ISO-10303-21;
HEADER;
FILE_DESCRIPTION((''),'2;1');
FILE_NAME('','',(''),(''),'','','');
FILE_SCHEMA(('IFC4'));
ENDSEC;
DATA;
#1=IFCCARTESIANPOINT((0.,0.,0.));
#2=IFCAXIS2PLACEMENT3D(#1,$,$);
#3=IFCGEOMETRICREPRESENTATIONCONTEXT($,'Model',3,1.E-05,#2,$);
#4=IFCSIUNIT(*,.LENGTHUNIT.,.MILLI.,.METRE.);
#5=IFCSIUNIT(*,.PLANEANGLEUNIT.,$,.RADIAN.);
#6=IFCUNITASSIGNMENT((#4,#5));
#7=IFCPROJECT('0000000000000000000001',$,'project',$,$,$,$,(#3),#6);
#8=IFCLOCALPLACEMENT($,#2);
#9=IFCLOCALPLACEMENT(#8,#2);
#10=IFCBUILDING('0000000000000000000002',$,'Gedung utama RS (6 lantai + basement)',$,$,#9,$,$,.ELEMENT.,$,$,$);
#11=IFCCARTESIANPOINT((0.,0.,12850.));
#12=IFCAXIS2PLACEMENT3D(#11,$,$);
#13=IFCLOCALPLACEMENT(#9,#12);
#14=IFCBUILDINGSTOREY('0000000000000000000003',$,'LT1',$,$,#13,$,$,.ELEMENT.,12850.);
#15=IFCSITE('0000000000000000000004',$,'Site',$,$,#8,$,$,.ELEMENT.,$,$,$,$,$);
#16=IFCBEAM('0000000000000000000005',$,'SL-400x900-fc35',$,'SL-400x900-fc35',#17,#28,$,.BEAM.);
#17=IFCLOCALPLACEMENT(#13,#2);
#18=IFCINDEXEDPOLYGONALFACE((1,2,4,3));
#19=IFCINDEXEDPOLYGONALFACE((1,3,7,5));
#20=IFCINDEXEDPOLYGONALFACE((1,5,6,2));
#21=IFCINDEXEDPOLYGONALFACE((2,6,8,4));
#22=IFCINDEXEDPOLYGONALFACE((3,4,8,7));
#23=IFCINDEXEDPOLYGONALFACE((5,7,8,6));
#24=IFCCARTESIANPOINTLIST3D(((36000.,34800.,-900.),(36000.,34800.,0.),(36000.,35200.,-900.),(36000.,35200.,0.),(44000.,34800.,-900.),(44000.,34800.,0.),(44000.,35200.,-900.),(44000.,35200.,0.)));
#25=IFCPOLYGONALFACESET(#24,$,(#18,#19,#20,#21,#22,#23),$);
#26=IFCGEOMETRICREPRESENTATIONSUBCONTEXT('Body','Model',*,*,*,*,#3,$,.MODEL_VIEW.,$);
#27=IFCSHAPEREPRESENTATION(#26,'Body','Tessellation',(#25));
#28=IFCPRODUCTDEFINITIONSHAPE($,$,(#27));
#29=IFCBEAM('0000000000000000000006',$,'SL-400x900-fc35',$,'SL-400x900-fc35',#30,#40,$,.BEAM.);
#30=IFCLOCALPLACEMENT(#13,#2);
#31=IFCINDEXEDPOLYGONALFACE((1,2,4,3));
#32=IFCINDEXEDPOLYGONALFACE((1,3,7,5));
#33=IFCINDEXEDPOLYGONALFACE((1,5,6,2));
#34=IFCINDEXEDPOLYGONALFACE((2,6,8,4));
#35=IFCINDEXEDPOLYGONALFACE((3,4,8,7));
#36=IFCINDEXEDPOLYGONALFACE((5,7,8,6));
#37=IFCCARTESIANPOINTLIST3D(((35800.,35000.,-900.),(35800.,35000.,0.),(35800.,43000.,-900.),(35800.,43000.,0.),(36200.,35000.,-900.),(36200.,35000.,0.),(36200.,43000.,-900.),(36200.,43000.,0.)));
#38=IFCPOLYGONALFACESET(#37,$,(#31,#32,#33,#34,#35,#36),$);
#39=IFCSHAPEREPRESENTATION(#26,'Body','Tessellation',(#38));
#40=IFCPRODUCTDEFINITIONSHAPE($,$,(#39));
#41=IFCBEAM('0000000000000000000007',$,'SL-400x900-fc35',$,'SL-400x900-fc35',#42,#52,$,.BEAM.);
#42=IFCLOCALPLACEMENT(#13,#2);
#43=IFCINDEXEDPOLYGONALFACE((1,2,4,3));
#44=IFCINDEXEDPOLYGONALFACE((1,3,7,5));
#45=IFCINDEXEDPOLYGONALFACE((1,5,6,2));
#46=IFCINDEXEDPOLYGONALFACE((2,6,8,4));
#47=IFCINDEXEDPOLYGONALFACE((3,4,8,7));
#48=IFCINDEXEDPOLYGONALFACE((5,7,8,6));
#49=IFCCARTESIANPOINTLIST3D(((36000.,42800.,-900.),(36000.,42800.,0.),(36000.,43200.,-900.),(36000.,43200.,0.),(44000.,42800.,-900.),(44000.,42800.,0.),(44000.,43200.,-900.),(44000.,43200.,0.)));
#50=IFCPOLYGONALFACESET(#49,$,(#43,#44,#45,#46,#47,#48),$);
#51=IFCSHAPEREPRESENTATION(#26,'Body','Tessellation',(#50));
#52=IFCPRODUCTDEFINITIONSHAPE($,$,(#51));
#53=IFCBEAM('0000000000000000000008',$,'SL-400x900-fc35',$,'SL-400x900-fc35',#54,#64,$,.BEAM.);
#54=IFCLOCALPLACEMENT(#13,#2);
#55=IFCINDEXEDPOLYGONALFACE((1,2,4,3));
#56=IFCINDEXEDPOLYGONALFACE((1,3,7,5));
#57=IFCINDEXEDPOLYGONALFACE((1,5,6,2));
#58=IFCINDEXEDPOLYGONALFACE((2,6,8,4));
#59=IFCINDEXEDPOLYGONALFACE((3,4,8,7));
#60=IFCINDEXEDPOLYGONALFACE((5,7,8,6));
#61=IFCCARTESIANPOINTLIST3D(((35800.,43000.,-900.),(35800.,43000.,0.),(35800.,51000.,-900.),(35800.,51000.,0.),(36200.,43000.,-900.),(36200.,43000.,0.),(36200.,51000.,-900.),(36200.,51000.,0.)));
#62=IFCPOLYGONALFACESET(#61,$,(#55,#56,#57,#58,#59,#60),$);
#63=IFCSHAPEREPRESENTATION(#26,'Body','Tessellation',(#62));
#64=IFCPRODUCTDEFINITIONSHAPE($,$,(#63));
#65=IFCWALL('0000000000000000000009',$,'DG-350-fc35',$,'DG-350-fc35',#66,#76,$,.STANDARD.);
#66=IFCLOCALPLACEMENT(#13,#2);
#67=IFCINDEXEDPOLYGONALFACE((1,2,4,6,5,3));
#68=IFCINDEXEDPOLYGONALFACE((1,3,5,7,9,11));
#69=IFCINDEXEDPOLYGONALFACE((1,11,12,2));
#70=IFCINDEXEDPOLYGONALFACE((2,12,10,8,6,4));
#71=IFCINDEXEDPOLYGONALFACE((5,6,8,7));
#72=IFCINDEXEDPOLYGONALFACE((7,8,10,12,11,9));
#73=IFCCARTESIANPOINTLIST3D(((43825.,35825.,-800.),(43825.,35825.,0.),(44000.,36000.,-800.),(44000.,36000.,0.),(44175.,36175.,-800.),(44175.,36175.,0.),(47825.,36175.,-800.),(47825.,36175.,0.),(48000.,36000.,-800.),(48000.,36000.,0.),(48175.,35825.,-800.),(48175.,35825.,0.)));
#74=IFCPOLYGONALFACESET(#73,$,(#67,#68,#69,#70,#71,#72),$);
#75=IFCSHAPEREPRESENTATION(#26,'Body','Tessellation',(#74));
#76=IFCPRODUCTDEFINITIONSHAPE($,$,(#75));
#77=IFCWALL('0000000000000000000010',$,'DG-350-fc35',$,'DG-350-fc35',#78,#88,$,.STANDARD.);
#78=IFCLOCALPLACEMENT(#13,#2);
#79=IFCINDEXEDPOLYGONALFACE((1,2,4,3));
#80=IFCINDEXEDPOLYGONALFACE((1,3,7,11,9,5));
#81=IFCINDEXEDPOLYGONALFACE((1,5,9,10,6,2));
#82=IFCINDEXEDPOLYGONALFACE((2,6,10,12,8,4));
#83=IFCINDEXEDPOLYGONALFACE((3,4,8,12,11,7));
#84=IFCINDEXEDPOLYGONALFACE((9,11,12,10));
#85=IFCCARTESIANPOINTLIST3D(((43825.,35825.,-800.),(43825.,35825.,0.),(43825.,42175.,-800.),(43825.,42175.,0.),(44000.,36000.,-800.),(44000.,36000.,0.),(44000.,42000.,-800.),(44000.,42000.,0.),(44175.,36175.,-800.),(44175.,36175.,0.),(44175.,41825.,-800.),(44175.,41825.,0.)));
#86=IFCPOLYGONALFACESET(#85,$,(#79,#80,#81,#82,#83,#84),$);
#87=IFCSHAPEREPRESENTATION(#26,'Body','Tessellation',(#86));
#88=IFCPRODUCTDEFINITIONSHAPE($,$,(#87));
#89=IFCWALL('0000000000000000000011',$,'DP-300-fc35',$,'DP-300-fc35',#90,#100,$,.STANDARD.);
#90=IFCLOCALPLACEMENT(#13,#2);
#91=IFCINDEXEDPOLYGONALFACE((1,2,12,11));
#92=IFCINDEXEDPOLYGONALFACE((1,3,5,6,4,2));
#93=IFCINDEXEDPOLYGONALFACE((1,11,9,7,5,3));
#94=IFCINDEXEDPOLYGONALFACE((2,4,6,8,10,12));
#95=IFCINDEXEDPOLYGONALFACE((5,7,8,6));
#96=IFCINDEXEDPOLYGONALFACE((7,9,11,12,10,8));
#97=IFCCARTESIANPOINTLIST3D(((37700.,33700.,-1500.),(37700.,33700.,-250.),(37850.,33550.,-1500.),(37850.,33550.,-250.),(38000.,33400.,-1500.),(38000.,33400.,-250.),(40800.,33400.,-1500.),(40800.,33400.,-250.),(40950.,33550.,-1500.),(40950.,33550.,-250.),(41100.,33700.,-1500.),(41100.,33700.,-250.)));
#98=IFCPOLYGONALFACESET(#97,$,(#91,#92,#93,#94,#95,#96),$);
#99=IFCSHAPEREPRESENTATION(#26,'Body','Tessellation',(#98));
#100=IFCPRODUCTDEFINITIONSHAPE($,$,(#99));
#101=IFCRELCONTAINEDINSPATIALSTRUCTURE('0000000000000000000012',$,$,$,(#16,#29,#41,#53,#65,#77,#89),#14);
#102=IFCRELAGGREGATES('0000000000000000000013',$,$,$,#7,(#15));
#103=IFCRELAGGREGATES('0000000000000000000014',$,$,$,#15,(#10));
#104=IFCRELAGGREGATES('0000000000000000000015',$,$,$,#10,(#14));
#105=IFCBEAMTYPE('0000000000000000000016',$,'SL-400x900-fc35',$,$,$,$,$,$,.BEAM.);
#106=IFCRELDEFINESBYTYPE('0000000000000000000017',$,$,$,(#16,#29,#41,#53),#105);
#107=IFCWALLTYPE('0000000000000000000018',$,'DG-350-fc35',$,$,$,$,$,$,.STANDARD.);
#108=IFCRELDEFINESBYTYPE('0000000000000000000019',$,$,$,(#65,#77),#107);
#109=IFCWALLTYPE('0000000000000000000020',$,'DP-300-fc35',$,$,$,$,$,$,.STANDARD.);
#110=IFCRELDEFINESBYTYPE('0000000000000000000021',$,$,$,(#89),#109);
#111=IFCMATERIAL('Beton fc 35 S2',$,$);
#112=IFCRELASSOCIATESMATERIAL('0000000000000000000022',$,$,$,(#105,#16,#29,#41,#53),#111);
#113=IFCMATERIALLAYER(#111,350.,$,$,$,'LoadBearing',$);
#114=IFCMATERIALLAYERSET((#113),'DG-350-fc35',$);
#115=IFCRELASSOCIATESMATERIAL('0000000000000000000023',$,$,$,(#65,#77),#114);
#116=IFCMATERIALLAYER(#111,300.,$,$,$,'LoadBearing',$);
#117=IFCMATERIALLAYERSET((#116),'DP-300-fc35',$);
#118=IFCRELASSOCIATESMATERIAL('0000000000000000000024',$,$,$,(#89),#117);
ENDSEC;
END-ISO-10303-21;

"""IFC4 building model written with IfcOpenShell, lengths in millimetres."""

from ifc_helpers import new_model, si_unit, frame, origin, origin_2d, place, context, subcontext, project, spatial, polyline, rectangle, outline, extrude, material, layer, layer_set, layer_usage, material_profile, profile_set, profile_usage, type_object, element, save


model = new_model("IFC4")

# Units and contexts
model_context = context("Model", 3, precision=1e-05, world=origin())
body_context = subcontext(model_context, "Body", "Model", "MODEL_VIEW")
ifc_project = project(units=[si_unit("LENGTHUNIT", "METRE", prefix="MILLI"), si_unit("PLANEANGLEUNIT", "RADIAN")], contexts=[model_context])

# Site, building, storey
site_placement = place(None, origin())
site = spatial("IfcSite", under=ifc_project, at=site_placement, Name="Site", CompositionType="ELEMENT")
building_placement = place(site_placement, origin())
building = spatial("IfcBuilding", under=site, at=building_placement, Name="Gedung utama RS (6 lantai + basement)", CompositionType="ELEMENT")
storey_placement = place(building_placement, frame((0.0, 0.0, 12850.0)))
storey = spatial("IfcBuildingStorey", under=building, at=storey_placement, Name="LT1", CompositionType="ELEMENT", Elevation=12850.0)

# Beams
ifc_material = material(Name="Beton fc 35 S2")
ifc_material_profile_1 = material_profile(ifc_material, rectangle(XDim=400.0, YDim=900.0, at=origin_2d()), Name="SL-400x900-fc35")
ifc_profile_set_1 = profile_set([ifc_material_profile_1], Name="SL-400x900-fc35")
ifc_profile_usage_1 = profile_usage(ifc_profile_set_1, cardinal=8)
beam_type_1 = type_object("IfcBeamType", Name="SL-400x900-fc35", PredefinedType="BEAM", material=ifc_profile_set_1)
beam_1_placement = place(storey_placement, frame((36000.0, 35000.0, -450.0)))
element("IfcBeam", 1, at=beam_1_placement, inside=storey, type_object=beam_type_1, material=ifc_profile_usage_1, Name="SL-400x900-fc35", ObjectType="SL-400x900-fc35", PredefinedType="BEAM", context=body_context, shape_type="SweptSolid", body=[
    extrude(rectangle(XDim=400.0, YDim=900.0, at=origin_2d()), frame((0.0, 0.0, 0.0), z_axis=(1.0, 0.0, 0.0), x_axis=(0.0, 1.0, 0.0)), (0.0, 0.0, 1.0), 8000.0),
])
beam_2_placement = place(storey_placement, frame((36000.0, 35000.0, -450.0)))
element("IfcBeam", 2, at=beam_2_placement, inside=storey, type_object=beam_type_1, material=ifc_profile_usage_1, Name="SL-400x900-fc35", ObjectType="SL-400x900-fc35", PredefinedType="BEAM", context=body_context, shape_type="SweptSolid", body=[
    extrude(rectangle(XDim=400.0, YDim=900.0, at=origin_2d()), frame((0.0, 0.0, 0.0), z_axis=(0.0, 1.0, 0.0), x_axis=(-1.0, 0.0, 0.0)), (0.0, 0.0, 1.0), 8000.0),
])
beam_3_placement = place(storey_placement, frame((36000.0, 43000.0, -450.0)))
element("IfcBeam", 3, at=beam_3_placement, inside=storey, type_object=beam_type_1, material=ifc_profile_usage_1, Name="SL-400x900-fc35", ObjectType="SL-400x900-fc35", PredefinedType="BEAM", context=body_context, shape_type="SweptSolid", body=[
    extrude(rectangle(XDim=400.0, YDim=900.0, at=origin_2d()), frame((0.0, 0.0, 0.0), z_axis=(1.0, 0.0, 0.0), x_axis=(0.0, 1.0, 0.0)), (0.0, 0.0, 1.0), 8000.0),
])
beam_4_placement = place(storey_placement, frame((36000.0, 43000.0, -450.0)))
element("IfcBeam", 4, at=beam_4_placement, inside=storey, type_object=beam_type_1, material=ifc_profile_usage_1, Name="SL-400x900-fc35", ObjectType="SL-400x900-fc35", PredefinedType="BEAM", context=body_context, shape_type="SweptSolid", body=[
    extrude(rectangle(XDim=400.0, YDim=900.0, at=origin_2d()), frame((0.0, 0.0, 0.0), z_axis=(0.0, 1.0, 0.0), x_axis=(-1.0, 0.0, 0.0)), (0.0, 0.0, 1.0), 8000.0),
])

# Walls
ifc_layer_1 = layer(ifc_material, 350.0, Category="LoadBearing")
ifc_layer_set_1 = layer_set([ifc_layer_1], Name="DG-350-fc35")
ifc_layer_usage_1 = layer_usage(ifc_layer_set_1, "AXIS2", "NEGATIVE", 175.0)
wall_type_1 = type_object("IfcWallType", Name="DG-350-fc35", PredefinedType="STANDARD")
wall_1_placement = place(storey_placement, frame((44000.0, 36000.0, -800.0), z_axis=(0.0, 0.0, 1.0), x_axis=(1.0, 0.0, 0.0)))
element("IfcWall", 5, at=wall_1_placement, inside=storey, type_object=wall_type_1, material=ifc_layer_usage_1, Name="DG-350-fc35", ObjectType="DG-350-fc35", PredefinedType="STANDARD", context=body_context, shape_type="SweptSolid", body=[
    extrude(outline(polyline([(-175.0, -175.0), (0.0, 0.0), (175.0, 175.0), (3825.0, 175.0), (4000.0, 0.0), (4175.0, -175.0), (-175.0, -175.0)])), origin(), (0.0, 0.0, 1.0), 800.0),
])
wall_2_placement = place(storey_placement, frame((44000.0, 42000.0, -800.0), z_axis=(0.0, 0.0, 1.0), x_axis=(0.0, -1.0, 0.0)))
element("IfcWall", 6, at=wall_2_placement, inside=storey, type_object=wall_type_1, material=ifc_layer_usage_1, Name="DG-350-fc35", ObjectType="DG-350-fc35", PredefinedType="STANDARD", context=body_context, shape_type="SweptSolid", body=[
    extrude(outline(polyline([(-175.0, -175.0), (0.0, 0.0), (175.0, 175.0), (5825.0, 175.0), (6000.0, 0.0), (6175.0, -175.0), (-175.0, -175.0)])), origin(), (0.0, 0.0, 1.0), 800.0),
])
ifc_layer_2 = layer(ifc_material, 300.0, Category="LoadBearing")
ifc_layer_set_2 = layer_set([ifc_layer_2], Name="DP-300-fc35")
ifc_layer_usage_2 = layer_usage(ifc_layer_set_2, "AXIS2", "NEGATIVE", 150.0)
wall_type_2 = type_object("IfcWallType", Name="DP-300-fc35", PredefinedType="STANDARD")
wall_3_placement = place(storey_placement, frame((40950.0, 33550.0, -1500.0), z_axis=(0.0, 0.0, 1.0), x_axis=(-1.0, 0.0, 0.0)))
element("IfcWall", 7, at=wall_3_placement, inside=storey, type_object=wall_type_2, material=ifc_layer_usage_2, Name="DP-300-fc35", ObjectType="DP-300-fc35", PredefinedType="STANDARD", context=body_context, shape_type="SweptSolid", body=[
    extrude(outline(polyline([(-150.0, -150.0), (0.0, 0.0), (150.0, 150.0), (2950.0, 150.0), (3100.0, 0.0), (3250.0, -150.0), (-150.0, -150.0)])), origin(), (0.0, 0.0, 1.0), 1250.0),
])

save(model, "model.ifc")
